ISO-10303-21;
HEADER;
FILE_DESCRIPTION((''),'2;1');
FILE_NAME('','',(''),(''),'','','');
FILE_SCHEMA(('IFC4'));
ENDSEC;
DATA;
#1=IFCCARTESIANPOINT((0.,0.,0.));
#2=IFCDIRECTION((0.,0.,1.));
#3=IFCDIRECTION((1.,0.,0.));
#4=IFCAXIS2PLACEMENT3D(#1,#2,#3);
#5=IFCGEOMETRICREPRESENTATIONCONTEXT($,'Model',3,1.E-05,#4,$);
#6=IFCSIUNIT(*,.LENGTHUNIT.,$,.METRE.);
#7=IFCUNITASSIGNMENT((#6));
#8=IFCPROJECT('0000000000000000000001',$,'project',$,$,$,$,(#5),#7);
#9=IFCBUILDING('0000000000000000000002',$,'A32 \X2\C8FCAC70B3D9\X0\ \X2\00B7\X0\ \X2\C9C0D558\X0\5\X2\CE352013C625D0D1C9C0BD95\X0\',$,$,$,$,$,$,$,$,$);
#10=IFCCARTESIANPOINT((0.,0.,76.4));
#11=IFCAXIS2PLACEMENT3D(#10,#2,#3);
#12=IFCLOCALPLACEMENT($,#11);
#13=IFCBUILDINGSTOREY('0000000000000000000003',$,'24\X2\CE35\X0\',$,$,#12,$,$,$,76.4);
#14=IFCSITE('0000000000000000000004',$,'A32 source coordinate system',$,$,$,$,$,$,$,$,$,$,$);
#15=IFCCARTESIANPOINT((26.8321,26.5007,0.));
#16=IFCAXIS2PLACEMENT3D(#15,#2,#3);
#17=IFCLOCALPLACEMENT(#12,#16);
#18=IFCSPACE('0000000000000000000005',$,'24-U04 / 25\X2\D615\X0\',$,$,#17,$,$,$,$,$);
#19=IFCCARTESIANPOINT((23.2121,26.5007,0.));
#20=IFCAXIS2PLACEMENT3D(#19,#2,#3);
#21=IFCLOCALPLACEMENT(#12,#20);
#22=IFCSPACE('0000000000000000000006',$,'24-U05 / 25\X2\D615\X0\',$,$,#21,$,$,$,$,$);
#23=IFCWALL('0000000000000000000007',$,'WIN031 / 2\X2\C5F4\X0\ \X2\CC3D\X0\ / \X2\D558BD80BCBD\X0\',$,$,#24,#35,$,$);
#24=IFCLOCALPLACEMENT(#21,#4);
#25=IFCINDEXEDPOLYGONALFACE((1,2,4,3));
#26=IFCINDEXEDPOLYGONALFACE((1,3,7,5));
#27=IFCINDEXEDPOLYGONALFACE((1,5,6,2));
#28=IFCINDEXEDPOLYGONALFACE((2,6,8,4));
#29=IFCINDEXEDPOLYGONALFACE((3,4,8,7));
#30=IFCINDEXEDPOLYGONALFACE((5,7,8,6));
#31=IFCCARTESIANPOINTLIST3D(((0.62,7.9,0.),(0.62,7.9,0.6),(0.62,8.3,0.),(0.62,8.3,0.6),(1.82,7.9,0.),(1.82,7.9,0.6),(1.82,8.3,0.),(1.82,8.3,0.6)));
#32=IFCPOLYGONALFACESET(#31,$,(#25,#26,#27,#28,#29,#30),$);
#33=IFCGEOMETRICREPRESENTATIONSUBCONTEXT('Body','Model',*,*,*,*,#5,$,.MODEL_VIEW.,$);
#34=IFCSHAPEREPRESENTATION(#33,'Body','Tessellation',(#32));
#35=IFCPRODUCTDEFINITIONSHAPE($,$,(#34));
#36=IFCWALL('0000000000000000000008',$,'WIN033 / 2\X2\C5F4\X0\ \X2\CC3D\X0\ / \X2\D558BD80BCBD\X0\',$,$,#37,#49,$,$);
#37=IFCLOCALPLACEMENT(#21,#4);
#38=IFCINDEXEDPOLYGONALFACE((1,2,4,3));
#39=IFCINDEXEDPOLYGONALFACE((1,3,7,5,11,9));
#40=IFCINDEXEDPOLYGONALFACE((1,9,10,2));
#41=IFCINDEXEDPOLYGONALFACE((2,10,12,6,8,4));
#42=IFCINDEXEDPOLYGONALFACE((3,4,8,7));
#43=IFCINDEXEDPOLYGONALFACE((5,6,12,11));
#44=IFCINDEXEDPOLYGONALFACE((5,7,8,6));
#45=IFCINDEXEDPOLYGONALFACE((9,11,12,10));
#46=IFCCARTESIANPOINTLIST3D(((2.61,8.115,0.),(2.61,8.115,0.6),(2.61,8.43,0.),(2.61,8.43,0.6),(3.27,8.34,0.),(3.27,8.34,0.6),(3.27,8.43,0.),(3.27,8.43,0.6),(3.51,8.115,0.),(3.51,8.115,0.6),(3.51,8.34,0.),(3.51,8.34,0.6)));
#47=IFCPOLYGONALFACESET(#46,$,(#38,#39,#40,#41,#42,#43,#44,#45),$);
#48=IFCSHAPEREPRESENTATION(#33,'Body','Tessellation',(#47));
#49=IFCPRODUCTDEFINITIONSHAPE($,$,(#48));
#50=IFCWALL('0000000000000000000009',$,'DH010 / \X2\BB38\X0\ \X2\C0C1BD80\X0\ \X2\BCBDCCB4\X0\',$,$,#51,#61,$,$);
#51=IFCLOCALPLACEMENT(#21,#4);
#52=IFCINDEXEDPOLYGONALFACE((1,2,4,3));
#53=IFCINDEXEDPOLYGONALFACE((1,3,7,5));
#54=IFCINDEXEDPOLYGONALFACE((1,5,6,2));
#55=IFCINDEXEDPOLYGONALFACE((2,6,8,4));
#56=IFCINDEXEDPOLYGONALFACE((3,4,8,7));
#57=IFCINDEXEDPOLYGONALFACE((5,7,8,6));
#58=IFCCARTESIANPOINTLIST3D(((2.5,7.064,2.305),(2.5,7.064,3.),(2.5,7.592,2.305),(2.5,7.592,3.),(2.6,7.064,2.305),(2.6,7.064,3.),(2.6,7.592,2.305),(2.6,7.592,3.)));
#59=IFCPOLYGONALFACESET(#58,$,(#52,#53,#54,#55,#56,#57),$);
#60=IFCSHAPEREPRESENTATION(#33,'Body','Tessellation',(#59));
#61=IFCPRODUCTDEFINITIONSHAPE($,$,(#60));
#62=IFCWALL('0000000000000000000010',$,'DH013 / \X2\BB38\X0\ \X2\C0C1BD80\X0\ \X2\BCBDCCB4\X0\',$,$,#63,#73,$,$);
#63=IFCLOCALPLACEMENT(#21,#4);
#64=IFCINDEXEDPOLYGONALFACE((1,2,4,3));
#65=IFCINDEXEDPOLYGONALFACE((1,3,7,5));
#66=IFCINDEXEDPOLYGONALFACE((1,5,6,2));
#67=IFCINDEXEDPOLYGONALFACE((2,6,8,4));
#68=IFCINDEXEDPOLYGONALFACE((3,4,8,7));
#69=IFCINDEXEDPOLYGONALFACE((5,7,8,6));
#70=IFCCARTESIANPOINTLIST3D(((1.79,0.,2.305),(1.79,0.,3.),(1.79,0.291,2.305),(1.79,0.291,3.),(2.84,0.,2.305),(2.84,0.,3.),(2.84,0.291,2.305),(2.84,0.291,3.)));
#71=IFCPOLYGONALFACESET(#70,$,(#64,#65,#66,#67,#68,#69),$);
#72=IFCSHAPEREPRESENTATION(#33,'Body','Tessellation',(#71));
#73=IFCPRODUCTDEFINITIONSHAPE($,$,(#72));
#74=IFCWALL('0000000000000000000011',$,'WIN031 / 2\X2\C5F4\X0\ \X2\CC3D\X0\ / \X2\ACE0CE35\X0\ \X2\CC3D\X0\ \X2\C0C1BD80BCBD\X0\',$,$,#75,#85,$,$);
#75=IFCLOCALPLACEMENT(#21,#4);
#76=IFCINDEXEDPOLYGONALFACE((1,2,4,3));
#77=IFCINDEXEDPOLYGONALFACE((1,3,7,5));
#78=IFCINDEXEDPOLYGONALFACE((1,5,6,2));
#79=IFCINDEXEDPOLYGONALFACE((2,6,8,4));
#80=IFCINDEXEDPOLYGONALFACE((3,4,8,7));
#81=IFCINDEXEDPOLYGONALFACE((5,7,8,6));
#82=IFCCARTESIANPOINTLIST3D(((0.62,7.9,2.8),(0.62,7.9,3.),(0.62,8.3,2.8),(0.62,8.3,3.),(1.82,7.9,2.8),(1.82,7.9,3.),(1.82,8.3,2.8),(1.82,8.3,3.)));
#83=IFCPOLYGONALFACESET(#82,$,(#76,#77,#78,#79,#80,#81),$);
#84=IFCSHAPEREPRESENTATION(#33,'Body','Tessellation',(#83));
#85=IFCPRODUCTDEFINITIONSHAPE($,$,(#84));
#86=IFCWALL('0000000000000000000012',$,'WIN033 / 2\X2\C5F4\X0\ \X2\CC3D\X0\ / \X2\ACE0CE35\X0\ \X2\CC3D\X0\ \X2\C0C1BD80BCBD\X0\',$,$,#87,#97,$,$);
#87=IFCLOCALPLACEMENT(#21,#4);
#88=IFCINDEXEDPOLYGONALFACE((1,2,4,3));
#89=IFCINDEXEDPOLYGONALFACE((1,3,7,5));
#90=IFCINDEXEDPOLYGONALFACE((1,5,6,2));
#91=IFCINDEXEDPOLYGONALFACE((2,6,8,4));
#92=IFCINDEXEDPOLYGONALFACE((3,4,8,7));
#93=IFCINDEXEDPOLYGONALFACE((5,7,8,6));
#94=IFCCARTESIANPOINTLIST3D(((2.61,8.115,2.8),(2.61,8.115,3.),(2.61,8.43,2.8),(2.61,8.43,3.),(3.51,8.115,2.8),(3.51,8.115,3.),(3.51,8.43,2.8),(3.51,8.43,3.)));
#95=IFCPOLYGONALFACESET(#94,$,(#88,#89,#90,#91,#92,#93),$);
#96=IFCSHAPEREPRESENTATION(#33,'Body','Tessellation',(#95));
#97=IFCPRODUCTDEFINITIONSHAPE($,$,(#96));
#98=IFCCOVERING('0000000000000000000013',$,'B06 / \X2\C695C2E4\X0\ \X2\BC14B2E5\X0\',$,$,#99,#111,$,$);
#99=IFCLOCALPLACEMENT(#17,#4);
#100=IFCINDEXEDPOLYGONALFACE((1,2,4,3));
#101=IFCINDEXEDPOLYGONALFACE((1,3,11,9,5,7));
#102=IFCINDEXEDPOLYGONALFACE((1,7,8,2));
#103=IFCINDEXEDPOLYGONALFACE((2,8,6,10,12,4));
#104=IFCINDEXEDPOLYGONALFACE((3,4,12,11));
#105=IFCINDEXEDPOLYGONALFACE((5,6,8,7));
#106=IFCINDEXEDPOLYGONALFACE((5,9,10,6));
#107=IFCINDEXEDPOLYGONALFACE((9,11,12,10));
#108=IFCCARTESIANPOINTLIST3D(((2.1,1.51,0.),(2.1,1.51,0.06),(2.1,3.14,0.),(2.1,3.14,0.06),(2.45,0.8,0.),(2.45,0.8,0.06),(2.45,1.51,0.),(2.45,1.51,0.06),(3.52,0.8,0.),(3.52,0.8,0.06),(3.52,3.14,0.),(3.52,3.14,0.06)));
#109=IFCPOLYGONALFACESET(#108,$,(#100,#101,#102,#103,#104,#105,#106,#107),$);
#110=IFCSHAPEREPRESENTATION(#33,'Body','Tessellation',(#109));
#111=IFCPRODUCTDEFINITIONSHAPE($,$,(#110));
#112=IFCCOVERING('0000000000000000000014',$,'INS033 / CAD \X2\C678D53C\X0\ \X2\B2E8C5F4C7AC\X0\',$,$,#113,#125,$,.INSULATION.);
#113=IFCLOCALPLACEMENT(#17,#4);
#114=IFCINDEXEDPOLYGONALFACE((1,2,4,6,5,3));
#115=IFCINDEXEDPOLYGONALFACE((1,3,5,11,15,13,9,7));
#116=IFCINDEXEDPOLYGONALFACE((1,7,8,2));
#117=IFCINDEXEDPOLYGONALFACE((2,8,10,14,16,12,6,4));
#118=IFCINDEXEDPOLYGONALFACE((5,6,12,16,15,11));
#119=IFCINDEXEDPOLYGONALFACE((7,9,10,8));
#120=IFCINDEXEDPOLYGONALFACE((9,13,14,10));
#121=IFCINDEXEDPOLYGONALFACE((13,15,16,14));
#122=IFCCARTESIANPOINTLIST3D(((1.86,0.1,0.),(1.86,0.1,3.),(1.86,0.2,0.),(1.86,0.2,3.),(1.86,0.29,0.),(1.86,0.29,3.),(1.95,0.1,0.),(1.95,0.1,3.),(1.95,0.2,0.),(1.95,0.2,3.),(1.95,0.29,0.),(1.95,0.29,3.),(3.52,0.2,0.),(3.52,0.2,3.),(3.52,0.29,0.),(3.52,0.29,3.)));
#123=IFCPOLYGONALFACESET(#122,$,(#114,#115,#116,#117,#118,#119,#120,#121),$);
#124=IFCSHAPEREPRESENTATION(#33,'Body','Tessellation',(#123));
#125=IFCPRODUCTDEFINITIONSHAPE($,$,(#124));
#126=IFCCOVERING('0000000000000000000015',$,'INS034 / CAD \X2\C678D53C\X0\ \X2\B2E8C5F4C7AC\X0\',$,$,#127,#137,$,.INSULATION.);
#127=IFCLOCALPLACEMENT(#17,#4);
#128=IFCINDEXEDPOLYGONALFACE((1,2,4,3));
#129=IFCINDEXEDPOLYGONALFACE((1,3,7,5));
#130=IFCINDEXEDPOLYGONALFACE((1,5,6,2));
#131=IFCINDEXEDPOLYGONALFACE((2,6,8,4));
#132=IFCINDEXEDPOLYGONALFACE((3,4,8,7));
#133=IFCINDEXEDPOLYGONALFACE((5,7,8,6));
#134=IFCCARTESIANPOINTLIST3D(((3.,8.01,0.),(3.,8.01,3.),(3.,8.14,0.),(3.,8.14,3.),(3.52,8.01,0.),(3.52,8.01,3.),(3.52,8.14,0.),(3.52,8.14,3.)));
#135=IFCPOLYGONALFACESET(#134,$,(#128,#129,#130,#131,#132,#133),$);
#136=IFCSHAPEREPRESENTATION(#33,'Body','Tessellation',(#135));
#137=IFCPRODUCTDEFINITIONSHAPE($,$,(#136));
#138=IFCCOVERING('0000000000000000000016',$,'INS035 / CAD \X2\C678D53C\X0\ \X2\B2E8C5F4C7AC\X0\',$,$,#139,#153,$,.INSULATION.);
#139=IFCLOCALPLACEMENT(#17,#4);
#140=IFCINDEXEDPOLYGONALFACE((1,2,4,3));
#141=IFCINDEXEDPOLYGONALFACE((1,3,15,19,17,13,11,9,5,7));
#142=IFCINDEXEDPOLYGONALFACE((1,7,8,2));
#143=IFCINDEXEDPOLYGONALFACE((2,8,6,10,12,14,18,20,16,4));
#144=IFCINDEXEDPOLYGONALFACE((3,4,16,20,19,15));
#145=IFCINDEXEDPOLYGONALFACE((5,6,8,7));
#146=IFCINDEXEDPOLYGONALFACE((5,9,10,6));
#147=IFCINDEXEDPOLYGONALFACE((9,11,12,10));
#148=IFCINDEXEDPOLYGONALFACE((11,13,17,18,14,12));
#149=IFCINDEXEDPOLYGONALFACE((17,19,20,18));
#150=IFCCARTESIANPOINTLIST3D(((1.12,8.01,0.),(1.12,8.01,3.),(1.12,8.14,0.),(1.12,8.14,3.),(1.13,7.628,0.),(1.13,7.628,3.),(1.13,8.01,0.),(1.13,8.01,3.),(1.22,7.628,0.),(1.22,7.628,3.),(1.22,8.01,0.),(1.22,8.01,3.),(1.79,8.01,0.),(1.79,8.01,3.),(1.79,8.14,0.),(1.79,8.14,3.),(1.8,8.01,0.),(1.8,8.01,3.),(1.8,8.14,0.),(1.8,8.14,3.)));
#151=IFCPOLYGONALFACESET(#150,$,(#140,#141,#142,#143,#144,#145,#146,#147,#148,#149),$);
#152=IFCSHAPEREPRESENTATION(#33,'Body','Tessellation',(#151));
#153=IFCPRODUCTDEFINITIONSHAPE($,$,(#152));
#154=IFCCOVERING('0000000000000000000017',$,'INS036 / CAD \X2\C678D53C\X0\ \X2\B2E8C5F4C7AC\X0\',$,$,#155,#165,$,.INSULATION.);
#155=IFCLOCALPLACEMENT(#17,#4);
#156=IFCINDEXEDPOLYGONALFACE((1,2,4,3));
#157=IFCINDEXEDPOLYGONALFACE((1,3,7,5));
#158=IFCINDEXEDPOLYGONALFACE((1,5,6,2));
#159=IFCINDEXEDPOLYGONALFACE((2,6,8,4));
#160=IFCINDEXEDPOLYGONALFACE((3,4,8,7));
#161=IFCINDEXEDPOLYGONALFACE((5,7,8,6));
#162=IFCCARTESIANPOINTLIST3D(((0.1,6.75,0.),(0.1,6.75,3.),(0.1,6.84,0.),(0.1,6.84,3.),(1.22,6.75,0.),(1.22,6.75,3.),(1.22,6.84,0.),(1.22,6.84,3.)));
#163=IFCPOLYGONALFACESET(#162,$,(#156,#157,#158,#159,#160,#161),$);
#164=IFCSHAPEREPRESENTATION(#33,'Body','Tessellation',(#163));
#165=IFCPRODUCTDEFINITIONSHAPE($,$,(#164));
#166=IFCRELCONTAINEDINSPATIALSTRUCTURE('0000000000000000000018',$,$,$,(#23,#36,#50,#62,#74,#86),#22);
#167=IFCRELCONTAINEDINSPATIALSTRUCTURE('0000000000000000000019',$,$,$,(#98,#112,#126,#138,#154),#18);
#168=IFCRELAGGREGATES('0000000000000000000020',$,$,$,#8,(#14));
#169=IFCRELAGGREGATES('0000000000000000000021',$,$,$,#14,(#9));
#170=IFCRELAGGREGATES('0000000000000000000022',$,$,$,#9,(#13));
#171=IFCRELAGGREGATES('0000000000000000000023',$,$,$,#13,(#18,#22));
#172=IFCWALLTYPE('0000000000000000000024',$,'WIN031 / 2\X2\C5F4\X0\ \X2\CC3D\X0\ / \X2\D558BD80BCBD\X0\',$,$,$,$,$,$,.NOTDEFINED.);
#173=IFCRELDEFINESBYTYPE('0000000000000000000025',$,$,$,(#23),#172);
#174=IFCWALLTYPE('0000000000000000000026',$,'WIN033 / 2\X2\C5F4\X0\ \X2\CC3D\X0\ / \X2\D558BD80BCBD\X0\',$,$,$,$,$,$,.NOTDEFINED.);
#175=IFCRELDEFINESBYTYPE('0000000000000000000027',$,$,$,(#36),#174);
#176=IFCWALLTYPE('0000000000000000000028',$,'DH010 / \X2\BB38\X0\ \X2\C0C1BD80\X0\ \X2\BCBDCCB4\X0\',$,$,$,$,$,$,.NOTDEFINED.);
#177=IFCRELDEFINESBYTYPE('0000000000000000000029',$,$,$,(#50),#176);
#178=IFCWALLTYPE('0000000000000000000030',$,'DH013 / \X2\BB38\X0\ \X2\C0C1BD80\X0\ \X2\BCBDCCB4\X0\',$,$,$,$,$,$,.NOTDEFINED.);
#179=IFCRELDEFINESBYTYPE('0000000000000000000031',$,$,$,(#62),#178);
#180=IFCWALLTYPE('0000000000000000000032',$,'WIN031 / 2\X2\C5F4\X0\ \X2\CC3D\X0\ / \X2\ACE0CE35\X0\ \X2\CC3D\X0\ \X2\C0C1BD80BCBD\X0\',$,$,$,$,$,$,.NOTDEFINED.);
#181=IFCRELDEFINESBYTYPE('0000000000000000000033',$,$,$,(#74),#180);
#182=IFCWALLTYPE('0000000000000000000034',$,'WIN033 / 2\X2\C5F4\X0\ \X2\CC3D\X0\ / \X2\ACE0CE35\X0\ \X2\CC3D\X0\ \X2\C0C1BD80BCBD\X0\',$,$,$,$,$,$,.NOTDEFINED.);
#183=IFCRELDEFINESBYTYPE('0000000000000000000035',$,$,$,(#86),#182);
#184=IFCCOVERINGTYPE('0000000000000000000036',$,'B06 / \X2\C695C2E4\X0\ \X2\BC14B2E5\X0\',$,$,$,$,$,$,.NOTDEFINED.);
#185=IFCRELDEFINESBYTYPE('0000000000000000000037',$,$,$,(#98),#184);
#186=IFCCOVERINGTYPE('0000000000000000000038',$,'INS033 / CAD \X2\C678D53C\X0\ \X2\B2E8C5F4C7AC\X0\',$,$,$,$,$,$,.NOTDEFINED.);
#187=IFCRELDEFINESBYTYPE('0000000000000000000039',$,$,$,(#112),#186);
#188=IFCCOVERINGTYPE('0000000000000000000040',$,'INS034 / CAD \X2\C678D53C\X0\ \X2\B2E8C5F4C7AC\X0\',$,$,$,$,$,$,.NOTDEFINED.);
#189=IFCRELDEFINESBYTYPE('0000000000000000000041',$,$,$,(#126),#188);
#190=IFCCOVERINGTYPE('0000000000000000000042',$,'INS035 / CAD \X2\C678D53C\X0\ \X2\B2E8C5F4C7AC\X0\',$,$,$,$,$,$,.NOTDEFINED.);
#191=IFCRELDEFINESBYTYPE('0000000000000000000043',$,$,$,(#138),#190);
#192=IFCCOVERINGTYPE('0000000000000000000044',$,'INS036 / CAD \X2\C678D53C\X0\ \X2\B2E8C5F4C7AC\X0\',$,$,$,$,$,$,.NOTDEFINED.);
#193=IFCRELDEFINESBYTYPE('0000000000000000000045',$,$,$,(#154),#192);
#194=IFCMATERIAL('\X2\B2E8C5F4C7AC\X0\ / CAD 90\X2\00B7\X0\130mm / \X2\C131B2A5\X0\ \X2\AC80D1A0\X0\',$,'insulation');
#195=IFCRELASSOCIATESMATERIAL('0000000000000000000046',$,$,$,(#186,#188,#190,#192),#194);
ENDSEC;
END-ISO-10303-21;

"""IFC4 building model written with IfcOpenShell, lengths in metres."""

from ifc_helpers import new_model, si_unit, frame, origin, origin_with_axes, place, context, subcontext, project, spatial, polyline, outline, extrude, source, transform, mapped, material, type_object, type_shapes, element, save


model = new_model("IFC4")

# Units and contexts
model_context = context("Model", 3, precision=1e-05, world=origin_with_axes())
body_context = subcontext(model_context, "Body", "Model", "MODEL_VIEW")
ifc_project = project(units=[si_unit("LENGTHUNIT", "METRE")], contexts=[model_context])

# Site, building, storey, space
storey_placement = place(None, frame((0.0, 0.0, 76.4), z_axis=(0.0, 0.0, 1.0), x_axis=(1.0, 0.0, 0.0)))
space_1_placement = place(storey_placement, frame((26.8321, 26.5007, 0.0), z_axis=(0.0, 0.0, 1.0), x_axis=(1.0, 0.0, 0.0)))
site = spatial("IfcSite", under=ifc_project, Name="A32 source coordinate system")
building = spatial("IfcBuilding", under=site, Name="A32 주거동 · 지하5층–옥탑지붕")
storey = spatial("IfcBuildingStorey", under=building, at=storey_placement, Name="24층", Elevation=76.4)
space_1 = spatial("IfcSpace", under=storey, at=space_1_placement, Name="24-U04 / 25형")

# Shared definitions
space_2_placement = place(storey_placement, frame((23.2121, 26.5007, 0.0), z_axis=(0.0, 0.0, 1.0), x_axis=(1.0, 0.0, 0.0)))
space_2 = spatial("IfcSpace", under=storey, at=space_2_placement, Name="24-U05 / 25형")

# Walls
wall_type_1 = type_object("IfcWallType", Name="WIN031 / 2열 창 / 하부벽", PredefinedType="NOTDEFINED")
shared_shape_1 = source(origin(), body_context, "Body", "SweptSolid", [
    extrude(outline(polyline([(0.62, 8.3), (1.82, 8.3), (1.82, 7.9), (0.62, 7.9), (0.62, 8.3)])), origin(), (0.0, 0.0, 1.0), 0.6),
])
type_shapes(wall_type_1, [shared_shape_1])
wall_1_placement = place(space_2_placement, origin_with_axes())
element("IfcWall", 1, at=wall_1_placement, inside=space_2, type_object=wall_type_1, Name="WIN031 / 2열 창 / 하부벽", context=body_context, shape_type="MappedRepresentation", body=[
    mapped(shared_shape_1, transform((0.0, 0.0, 0.0), scale=1.0)),
])
wall_type_2 = type_object("IfcWallType", Name="WIN033 / 2열 창 / 하부벽", PredefinedType="NOTDEFINED")
shared_shape_2 = source(origin(), body_context, "Body", "SweptSolid", [
    extrude(outline(polyline([(2.61, 8.43), (3.27, 8.43), (3.27, 8.34), (3.51, 8.34), (3.51, 8.115), (2.61, 8.115), (2.61, 8.43)])), origin(), (0.0, 0.0, 1.0), 0.6),
])
type_shapes(wall_type_2, [shared_shape_2])
wall_2_placement = place(space_2_placement, origin_with_axes())
element("IfcWall", 2, at=wall_2_placement, inside=space_2, type_object=wall_type_2, Name="WIN033 / 2열 창 / 하부벽", context=body_context, shape_type="MappedRepresentation", body=[
    mapped(shared_shape_2, transform((0.0, 0.0, 0.0), scale=1.0)),
])
wall_type_3 = type_object("IfcWallType", Name="DH010 / 문 상부 벽체", PredefinedType="NOTDEFINED")
shared_shape_3 = source(origin(), body_context, "Body", "SweptSolid", [
    extrude(outline(polyline([(2.5, 7.592), (2.6, 7.592), (2.6, 7.064), (2.5, 7.064), (2.5, 7.592)])), frame((0.0, 0.0, 2.305)), (0.0, 0.0, 1.0), 0.695),
])
type_shapes(wall_type_3, [shared_shape_3])
wall_3_placement = place(space_2_placement, origin_with_axes())
element("IfcWall", 3, at=wall_3_placement, inside=space_2, type_object=wall_type_3, Name="DH010 / 문 상부 벽체", context=body_context, shape_type="MappedRepresentation", body=[
    mapped(shared_shape_3, transform((0.0, 0.0, 0.0), scale=1.0)),
])
wall_type_4 = type_object("IfcWallType", Name="DH013 / 문 상부 벽체", PredefinedType="NOTDEFINED")
shared_shape_4 = source(origin(), body_context, "Body", "SweptSolid", [
    extrude(outline(polyline([(2.84, 0.291), (2.84, 0.0), (1.79, 0.0), (1.79, 0.291), (2.84, 0.291)])), frame((0.0, 0.0, 2.305)), (0.0, 0.0, 1.0), 0.695),
])
type_shapes(wall_type_4, [shared_shape_4])
wall_4_placement = place(space_2_placement, origin_with_axes())
element("IfcWall", 4, at=wall_4_placement, inside=space_2, type_object=wall_type_4, Name="DH013 / 문 상부 벽체", context=body_context, shape_type="MappedRepresentation", body=[
    mapped(shared_shape_4, transform((0.0, 0.0, 0.0), scale=1.0)),
])
wall_type_5 = type_object("IfcWallType", Name="WIN031 / 2열 창 / 고층 창 상부벽", PredefinedType="NOTDEFINED")
shared_shape_5 = source(origin(), body_context, "Body", "SweptSolid", [
    extrude(outline(polyline([(1.82, 7.9), (1.82, 8.3), (0.62, 8.3), (0.62, 7.9), (1.82, 7.9)])), frame((0.0, 0.0, 2.8)), (0.0, 0.0, 1.0), 0.2),
])
type_shapes(wall_type_5, [shared_shape_5])
wall_5_placement = place(space_2_placement, origin_with_axes())
element("IfcWall", 5, at=wall_5_placement, inside=space_2, type_object=wall_type_5, Name="WIN031 / 2열 창 / 고층 창 상부벽", context=body_context, shape_type="MappedRepresentation", body=[
    mapped(shared_shape_5, transform((0.0, 0.0, 0.0), scale=1.0)),
])
wall_type_6 = type_object("IfcWallType", Name="WIN033 / 2열 창 / 고층 창 상부벽", PredefinedType="NOTDEFINED")
shared_shape_6 = source(origin(), body_context, "Body", "SweptSolid", [
    extrude(outline(polyline([(3.51, 8.115), (3.51, 8.43), (2.61, 8.43), (2.61, 8.115), (3.51, 8.115)])), frame((0.0, 0.0, 2.8)), (0.0, 0.0, 1.0), 0.2),
])
type_shapes(wall_type_6, [shared_shape_6])
wall_6_placement = place(space_2_placement, origin_with_axes())
element("IfcWall", 6, at=wall_6_placement, inside=space_2, type_object=wall_type_6, Name="WIN033 / 2열 창 / 고층 창 상부벽", context=body_context, shape_type="MappedRepresentation", body=[
    mapped(shared_shape_6, transform((0.0, 0.0, 0.0), scale=1.0)),
])

# Coverings
covering_type_1 = type_object("IfcCoveringType", Name="B06 / 욕실 바닥", PredefinedType="NOTDEFINED")
shared_shape_7 = source(origin(), body_context, "Body", "SweptSolid", [
    extrude(outline(polyline([(2.1, 3.14), (3.52, 3.14), (3.52, 0.8), (2.45, 0.8), (2.45, 1.51), (2.1, 1.51), (2.1, 3.14)])), origin(), (0.0, 0.0, 1.0), 0.06),
])
type_shapes(covering_type_1, [shared_shape_7])
covering_1_placement = place(space_1_placement, origin_with_axes())
element("IfcCovering", 7, at=covering_1_placement, inside=space_1, type_object=covering_type_1, Name="B06 / 욕실 바닥", context=body_context, shape_type="MappedRepresentation", body=[
    mapped(shared_shape_7, transform((0.0, 0.0, 0.0), scale=1.0)),
])
ifc_material = material(Name="단열재 / CAD 90·130mm / 성능 검토", Category="insulation")
covering_type_2 = type_object("IfcCoveringType", Name="INS033 / CAD 외피 단열재", PredefinedType="NOTDEFINED", material=ifc_material)
shared_shape_8 = source(origin(), body_context, "Body", "SweptSolid", [
    extrude(outline(polyline([(1.95, 0.29), (3.52, 0.29), (3.52, 0.2), (1.95, 0.2), (1.95, 0.1), (1.86, 0.1), (1.86, 0.2), (1.86, 0.29), (1.95, 0.29)])), origin(), (0.0, 0.0, 1.0), 3.0),
])
type_shapes(covering_type_2, [shared_shape_8])
covering_2_placement = place(space_1_placement, origin_with_axes())
element("IfcCovering", 8, at=covering_2_placement, inside=space_1, type_object=covering_type_2, Name="INS033 / CAD 외피 단열재", PredefinedType="INSULATION", context=body_context, shape_type="MappedRepresentation", body=[
    mapped(shared_shape_8, transform((0.0, 0.0, 0.0), scale=1.0)),
])
covering_type_3 = type_object("IfcCoveringType", Name="INS034 / CAD 외피 단열재", PredefinedType="NOTDEFINED", material=ifc_material)
shared_shape_9 = source(origin(), body_context, "Body", "SweptSolid", [
    extrude(outline(polyline([(3.52, 8.01), (3.0, 8.01), (3.0, 8.14), (3.52, 8.14), (3.52, 8.01)])), origin(), (0.0, 0.0, 1.0), 3.0),
])
type_shapes(covering_type_3, [shared_shape_9])
covering_3_placement = place(space_1_placement, origin_with_axes())
element("IfcCovering", 9, at=covering_3_placement, inside=space_1, type_object=covering_type_3, Name="INS034 / CAD 외피 단열재", PredefinedType="INSULATION", context=body_context, shape_type="MappedRepresentation", body=[
    mapped(shared_shape_9, transform((0.0, 0.0, 0.0), scale=1.0)),
])
covering_type_4 = type_object("IfcCoveringType", Name="INS035 / CAD 외피 단열재", PredefinedType="NOTDEFINED", material=ifc_material)
shared_shape_10 = source(origin(), body_context, "Body", "SweptSolid", [
    extrude(outline(polyline([(1.8, 8.01), (1.79, 8.01), (1.22, 8.01), (1.22, 7.628), (1.13, 7.628), (1.13, 8.01), (1.12, 8.01), (1.12, 8.14), (1.79, 8.14), (1.8, 8.14), (1.8, 8.01)])), origin(), (0.0, 0.0, 1.0), 3.0),
])
type_shapes(covering_type_4, [shared_shape_10])
covering_4_placement = place(space_1_placement, origin_with_axes())
element("IfcCovering", 10, at=covering_4_placement, inside=space_1, type_object=covering_type_4, Name="INS035 / CAD 외피 단열재", PredefinedType="INSULATION", context=body_context, shape_type="MappedRepresentation", body=[
    mapped(shared_shape_10, transform((0.0, 0.0, 0.0), scale=1.0)),
])
covering_type_5 = type_object("IfcCoveringType", Name="INS036 / CAD 외피 단열재", PredefinedType="NOTDEFINED", material=ifc_material)
shared_shape_11 = source(origin(), body_context, "Body", "SweptSolid", [
    extrude(outline(polyline([(1.22, 6.84), (1.22, 6.75), (0.1, 6.75), (0.1, 6.84), (1.22, 6.84)])), origin(), (0.0, 0.0, 1.0), 3.0),
])
type_shapes(covering_type_5, [shared_shape_11])
covering_5_placement = place(space_1_placement, origin_with_axes())
element("IfcCovering", 11, at=covering_5_placement, inside=space_1, type_object=covering_type_5, Name="INS036 / CAD 외피 단열재", PredefinedType="INSULATION", context=body_context, shape_type="MappedRepresentation", body=[
    mapped(shared_shape_11, transform((0.0, 0.0, 0.0), scale=1.0)),
])

save(model, "model.ifc")
